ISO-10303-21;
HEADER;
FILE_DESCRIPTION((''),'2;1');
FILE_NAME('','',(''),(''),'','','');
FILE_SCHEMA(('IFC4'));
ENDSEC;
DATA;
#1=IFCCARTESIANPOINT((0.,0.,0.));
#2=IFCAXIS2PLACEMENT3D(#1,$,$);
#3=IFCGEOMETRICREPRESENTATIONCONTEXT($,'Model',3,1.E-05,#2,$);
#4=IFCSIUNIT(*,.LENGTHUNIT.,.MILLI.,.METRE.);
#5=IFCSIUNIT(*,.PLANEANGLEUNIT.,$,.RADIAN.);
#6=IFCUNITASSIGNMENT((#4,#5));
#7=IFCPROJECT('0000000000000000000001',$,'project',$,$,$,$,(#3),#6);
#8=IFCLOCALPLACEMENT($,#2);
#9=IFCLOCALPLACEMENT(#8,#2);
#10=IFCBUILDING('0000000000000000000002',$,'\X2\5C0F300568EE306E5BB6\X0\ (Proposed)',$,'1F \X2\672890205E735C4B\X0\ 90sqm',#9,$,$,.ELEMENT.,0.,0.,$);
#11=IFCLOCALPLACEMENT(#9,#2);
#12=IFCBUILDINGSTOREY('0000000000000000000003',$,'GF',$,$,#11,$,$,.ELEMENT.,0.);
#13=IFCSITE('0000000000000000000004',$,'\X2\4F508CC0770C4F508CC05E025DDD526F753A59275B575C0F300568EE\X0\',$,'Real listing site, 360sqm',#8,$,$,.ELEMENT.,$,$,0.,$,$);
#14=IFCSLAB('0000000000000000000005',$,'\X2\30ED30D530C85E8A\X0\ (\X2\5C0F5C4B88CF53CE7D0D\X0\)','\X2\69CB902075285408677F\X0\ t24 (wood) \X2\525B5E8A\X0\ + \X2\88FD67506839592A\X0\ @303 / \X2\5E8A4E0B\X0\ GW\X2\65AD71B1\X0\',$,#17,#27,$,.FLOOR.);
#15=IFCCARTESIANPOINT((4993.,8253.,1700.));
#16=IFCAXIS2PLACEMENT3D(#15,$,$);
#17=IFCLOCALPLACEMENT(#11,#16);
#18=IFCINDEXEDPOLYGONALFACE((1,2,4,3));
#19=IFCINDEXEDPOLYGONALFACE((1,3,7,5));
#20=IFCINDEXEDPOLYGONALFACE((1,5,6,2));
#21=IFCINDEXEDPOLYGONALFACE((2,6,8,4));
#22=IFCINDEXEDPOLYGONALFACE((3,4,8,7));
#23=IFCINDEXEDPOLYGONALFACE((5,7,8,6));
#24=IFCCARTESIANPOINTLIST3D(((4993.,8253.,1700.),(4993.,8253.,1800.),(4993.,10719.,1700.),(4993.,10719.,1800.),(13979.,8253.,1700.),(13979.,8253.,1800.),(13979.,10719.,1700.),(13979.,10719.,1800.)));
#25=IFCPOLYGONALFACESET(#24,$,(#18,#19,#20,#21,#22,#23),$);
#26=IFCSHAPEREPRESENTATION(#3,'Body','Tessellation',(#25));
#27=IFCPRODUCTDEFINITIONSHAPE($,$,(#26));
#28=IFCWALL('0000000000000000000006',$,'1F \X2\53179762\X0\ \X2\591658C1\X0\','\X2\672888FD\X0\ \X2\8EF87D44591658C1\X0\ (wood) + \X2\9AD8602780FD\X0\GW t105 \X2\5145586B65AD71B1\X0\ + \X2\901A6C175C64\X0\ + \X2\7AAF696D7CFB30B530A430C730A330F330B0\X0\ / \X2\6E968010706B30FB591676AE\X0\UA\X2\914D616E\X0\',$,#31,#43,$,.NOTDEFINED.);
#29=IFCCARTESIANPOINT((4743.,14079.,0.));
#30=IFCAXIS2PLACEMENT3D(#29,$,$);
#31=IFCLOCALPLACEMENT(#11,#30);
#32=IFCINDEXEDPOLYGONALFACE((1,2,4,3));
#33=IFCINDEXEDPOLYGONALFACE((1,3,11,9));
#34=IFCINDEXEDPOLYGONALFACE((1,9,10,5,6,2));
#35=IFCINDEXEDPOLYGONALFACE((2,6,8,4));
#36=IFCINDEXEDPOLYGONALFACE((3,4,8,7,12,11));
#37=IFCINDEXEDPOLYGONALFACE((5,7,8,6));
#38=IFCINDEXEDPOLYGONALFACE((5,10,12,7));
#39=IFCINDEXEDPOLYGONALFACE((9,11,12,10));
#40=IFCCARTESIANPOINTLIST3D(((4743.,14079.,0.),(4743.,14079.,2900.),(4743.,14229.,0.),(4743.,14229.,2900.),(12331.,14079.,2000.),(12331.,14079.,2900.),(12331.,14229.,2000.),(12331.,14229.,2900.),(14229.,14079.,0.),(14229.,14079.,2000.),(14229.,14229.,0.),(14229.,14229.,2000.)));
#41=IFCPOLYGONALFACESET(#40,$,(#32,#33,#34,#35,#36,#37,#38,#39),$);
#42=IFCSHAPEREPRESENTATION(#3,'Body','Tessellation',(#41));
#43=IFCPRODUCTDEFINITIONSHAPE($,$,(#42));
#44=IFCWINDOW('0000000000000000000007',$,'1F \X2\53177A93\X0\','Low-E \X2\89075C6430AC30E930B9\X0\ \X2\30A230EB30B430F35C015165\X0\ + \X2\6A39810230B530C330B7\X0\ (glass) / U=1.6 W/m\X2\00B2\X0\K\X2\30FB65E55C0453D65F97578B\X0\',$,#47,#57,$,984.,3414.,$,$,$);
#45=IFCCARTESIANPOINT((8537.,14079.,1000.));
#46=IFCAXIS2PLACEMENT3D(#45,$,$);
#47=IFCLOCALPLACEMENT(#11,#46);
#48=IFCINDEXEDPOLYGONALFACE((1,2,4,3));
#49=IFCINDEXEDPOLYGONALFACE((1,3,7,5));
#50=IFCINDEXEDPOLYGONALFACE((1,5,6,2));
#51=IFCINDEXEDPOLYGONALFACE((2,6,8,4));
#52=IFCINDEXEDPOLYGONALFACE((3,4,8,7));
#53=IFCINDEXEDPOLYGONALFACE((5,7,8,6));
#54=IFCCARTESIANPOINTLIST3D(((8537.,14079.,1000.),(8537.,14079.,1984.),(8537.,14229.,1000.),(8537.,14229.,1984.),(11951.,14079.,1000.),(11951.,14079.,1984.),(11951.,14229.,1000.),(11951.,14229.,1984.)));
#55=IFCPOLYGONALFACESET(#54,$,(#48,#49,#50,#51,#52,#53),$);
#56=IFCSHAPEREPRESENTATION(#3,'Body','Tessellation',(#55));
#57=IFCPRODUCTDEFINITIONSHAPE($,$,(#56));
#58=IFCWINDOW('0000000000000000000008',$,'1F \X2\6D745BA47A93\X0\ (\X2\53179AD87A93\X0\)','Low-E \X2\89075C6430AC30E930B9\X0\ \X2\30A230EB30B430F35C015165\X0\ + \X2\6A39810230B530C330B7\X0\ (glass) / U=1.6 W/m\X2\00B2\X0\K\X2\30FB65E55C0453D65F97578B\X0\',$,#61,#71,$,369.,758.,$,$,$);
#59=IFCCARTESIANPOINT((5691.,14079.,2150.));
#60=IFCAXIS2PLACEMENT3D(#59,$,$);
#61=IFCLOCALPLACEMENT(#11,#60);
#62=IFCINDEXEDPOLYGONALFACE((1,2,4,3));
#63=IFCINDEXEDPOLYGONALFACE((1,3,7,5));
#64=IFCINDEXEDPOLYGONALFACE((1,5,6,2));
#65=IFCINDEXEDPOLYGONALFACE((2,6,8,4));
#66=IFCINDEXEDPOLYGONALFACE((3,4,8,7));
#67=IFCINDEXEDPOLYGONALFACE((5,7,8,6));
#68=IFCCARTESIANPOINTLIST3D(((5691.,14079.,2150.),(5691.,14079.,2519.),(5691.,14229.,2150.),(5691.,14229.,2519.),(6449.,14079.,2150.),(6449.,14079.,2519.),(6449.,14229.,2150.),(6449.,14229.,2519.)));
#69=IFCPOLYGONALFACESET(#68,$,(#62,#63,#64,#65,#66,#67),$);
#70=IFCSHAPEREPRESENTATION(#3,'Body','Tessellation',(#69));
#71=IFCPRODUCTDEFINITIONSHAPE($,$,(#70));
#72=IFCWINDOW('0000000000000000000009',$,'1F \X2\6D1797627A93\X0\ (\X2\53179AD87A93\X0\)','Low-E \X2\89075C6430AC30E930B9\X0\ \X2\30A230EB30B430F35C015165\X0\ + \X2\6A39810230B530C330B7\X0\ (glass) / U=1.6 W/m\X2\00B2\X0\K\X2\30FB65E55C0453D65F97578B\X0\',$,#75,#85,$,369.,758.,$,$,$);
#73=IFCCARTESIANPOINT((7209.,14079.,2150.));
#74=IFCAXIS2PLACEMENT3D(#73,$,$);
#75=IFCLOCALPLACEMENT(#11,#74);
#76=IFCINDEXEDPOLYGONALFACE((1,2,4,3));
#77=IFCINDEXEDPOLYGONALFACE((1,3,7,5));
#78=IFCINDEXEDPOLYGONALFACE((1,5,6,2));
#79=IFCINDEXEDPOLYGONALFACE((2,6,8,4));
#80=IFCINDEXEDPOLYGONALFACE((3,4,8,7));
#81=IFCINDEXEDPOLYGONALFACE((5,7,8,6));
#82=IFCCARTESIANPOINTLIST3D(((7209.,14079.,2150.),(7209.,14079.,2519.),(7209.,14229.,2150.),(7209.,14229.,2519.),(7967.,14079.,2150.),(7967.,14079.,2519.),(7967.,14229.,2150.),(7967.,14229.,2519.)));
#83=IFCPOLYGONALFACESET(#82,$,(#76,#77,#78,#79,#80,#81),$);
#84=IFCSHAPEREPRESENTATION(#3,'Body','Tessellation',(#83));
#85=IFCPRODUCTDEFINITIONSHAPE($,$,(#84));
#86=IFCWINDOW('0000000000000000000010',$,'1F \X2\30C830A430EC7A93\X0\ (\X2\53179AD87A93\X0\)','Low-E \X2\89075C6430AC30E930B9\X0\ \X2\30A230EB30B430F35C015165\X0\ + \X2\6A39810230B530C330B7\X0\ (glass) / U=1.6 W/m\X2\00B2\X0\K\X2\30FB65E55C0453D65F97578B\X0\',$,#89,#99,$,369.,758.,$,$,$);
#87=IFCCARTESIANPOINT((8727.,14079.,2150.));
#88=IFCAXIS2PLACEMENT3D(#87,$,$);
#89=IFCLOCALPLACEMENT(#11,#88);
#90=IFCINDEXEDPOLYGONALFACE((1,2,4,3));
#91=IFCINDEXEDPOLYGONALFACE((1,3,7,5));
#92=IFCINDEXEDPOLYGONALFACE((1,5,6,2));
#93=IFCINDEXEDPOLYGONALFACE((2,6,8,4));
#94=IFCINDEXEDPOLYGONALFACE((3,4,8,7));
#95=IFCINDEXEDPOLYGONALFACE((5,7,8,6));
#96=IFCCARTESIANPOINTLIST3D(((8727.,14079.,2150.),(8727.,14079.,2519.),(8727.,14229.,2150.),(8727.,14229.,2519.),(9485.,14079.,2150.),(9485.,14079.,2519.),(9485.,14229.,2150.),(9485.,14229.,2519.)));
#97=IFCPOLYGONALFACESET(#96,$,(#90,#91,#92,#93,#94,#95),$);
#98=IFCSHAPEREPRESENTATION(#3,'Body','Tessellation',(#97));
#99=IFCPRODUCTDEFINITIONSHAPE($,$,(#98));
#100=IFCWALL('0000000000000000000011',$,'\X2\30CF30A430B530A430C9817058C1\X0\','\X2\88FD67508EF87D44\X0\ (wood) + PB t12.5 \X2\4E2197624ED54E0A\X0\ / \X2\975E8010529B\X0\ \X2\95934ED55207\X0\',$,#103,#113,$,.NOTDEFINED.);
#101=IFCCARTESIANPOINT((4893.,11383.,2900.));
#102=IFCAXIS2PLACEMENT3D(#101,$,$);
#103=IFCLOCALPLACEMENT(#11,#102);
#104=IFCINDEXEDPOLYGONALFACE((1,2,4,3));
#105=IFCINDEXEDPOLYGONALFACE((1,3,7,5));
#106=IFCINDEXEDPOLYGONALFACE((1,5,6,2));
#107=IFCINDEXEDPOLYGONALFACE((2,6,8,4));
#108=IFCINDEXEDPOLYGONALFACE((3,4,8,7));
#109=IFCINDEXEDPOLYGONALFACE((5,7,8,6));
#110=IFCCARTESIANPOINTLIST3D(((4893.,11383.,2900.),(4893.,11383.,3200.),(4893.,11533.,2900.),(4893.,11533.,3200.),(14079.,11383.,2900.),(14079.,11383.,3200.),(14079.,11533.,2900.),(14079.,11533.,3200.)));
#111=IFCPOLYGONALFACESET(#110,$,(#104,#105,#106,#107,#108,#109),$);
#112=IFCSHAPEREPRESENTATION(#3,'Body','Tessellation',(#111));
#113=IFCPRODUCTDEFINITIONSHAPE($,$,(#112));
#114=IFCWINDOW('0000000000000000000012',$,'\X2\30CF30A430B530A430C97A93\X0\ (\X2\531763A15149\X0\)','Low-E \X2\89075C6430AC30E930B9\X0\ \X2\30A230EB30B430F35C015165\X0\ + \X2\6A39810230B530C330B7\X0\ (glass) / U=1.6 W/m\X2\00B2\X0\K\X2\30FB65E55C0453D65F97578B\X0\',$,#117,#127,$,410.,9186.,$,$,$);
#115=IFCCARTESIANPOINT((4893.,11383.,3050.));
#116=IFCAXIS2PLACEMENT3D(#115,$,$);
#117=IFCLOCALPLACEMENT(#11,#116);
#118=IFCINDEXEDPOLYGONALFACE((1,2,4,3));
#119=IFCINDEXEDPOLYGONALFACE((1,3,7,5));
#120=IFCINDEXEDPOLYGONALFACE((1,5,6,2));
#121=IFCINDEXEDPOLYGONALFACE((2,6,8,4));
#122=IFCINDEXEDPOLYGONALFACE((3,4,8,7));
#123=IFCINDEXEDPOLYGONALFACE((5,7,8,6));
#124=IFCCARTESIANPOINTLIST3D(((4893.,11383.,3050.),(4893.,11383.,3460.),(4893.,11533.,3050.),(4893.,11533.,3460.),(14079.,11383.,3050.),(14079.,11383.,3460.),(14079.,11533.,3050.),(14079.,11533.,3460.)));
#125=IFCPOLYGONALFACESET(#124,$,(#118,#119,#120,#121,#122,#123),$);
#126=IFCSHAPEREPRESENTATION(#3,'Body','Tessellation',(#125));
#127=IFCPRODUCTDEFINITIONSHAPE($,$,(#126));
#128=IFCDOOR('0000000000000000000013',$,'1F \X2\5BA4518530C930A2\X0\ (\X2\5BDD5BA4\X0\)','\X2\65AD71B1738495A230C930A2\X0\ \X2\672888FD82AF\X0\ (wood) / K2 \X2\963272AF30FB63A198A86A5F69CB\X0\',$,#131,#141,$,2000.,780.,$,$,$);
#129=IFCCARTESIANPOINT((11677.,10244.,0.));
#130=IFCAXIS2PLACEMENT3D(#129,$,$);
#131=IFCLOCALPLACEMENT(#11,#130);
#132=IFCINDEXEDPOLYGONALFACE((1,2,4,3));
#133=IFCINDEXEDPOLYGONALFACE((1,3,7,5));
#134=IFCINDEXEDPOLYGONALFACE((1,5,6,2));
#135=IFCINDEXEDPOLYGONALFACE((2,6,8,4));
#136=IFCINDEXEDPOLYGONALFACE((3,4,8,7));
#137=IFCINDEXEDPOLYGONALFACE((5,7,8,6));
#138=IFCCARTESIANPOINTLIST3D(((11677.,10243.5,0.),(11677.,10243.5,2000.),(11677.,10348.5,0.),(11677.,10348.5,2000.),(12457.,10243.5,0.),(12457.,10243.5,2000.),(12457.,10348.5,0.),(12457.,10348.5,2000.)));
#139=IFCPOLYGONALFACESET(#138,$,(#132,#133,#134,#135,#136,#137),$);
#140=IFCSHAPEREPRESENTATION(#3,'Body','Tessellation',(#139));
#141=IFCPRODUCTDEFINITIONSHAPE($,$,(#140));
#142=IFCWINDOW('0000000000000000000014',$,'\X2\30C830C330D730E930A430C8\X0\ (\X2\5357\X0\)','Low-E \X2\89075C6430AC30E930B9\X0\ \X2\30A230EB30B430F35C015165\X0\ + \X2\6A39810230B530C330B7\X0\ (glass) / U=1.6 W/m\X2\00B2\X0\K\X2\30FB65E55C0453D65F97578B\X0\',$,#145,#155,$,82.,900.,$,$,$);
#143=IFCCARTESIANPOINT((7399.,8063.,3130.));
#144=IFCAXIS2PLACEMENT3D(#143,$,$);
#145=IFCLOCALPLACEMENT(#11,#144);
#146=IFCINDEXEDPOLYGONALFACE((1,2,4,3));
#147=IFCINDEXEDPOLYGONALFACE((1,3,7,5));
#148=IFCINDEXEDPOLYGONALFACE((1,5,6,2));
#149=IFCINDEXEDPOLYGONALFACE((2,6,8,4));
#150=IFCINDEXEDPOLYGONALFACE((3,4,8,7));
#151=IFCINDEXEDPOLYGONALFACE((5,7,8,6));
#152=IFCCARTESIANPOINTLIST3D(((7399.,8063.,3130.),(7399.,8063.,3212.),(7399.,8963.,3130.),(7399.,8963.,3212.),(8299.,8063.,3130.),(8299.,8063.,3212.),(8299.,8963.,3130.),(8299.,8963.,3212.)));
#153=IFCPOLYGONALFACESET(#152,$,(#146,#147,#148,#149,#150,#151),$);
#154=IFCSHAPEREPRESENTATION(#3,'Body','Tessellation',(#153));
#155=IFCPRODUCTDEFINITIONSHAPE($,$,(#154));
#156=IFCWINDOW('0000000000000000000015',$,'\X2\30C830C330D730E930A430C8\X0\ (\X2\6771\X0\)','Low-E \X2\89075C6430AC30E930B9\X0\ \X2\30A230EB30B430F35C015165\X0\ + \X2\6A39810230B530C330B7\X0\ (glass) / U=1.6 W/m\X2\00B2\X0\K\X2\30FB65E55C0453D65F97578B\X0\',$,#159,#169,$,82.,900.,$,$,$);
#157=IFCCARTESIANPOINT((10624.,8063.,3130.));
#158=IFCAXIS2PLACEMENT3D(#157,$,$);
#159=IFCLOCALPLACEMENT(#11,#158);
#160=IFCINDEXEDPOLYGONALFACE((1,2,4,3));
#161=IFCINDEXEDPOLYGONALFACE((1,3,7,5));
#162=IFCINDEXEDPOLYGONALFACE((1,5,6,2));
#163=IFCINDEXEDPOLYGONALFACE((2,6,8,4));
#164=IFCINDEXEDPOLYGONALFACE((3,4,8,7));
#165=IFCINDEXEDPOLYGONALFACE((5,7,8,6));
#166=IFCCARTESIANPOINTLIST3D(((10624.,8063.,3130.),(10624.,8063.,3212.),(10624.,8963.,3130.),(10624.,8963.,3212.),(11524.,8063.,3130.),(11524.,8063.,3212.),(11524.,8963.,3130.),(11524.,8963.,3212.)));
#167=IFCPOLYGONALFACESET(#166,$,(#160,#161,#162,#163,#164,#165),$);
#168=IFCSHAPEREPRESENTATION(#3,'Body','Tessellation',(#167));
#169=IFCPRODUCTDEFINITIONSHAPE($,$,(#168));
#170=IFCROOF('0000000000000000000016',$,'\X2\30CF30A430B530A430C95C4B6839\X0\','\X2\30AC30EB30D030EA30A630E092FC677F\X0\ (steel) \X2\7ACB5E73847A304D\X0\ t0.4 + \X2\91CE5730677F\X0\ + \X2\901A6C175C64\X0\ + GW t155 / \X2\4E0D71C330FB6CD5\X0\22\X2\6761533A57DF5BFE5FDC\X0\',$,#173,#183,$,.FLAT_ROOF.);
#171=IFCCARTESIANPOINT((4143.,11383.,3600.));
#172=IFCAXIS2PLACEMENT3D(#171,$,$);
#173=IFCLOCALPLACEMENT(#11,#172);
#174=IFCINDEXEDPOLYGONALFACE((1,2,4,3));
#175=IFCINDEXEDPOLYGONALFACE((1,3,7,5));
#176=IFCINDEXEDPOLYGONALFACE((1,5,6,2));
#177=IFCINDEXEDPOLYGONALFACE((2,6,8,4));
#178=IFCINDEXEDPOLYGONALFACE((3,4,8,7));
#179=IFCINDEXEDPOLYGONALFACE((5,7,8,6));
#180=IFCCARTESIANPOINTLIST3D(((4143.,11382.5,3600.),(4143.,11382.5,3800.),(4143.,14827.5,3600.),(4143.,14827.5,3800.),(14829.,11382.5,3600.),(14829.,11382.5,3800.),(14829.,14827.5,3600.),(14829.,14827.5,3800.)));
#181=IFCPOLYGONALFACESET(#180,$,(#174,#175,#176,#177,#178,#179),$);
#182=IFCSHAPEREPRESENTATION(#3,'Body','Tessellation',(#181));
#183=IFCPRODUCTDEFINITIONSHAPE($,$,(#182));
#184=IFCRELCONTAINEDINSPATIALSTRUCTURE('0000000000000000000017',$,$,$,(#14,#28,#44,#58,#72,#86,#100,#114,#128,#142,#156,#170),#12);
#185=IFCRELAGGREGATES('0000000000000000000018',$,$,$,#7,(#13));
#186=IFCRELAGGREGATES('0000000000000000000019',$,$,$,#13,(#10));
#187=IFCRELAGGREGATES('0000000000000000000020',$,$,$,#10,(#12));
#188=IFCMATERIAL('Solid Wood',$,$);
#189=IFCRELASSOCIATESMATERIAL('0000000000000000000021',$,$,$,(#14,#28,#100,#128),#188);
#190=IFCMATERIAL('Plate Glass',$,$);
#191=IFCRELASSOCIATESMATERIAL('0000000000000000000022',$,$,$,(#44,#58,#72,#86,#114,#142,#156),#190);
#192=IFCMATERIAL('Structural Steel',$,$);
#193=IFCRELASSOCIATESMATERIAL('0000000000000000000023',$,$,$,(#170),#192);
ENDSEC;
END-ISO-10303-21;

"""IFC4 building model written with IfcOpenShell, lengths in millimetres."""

from ifc_helpers import new_model, si_unit, frame, frame_2d, origin, place, context, project, spatial, rectangle, extrude, material, element, fill, save


model = new_model("IFC4")

# Units and contexts
model_context = context("Model", 3, precision=1e-05, world=origin())
ifc_project = project(units=[si_unit("LENGTHUNIT", "METRE", prefix="MILLI"), si_unit("PLANEANGLEUNIT", "RADIAN")], contexts=[model_context])

# Site, building, storey
site_placement = place(None, origin())
site = spatial("IfcSite", under=ifc_project, at=site_placement, Name="佐賀県佐賀市川副町大字小々森", ObjectType="Real listing site, 360sqm", CompositionType="ELEMENT", RefElevation=0.0)
building_placement = place(site_placement, origin())
building = spatial("IfcBuilding", under=site, at=building_placement, Name="小々森の家 (Proposed)", ObjectType="1F 木造平屋 90sqm", CompositionType="ELEMENT", ElevationOfRefHeight=0.0, ElevationOfTerrain=0.0)
storey_placement = place(building_placement, origin())
storey = spatial("IfcBuildingStorey", under=building, at=storey_placement, Name="GF", CompositionType="ELEMENT", Elevation=0.0)

# Slab
ifc_material_1 = material(Name="Solid Wood")
slab_placement = place(storey_placement, frame((4993.0, 8253.0, 1700.0)))
element("IfcSlab", 1, at=slab_placement, inside=storey, material=ifc_material_1, Name="ロフト床 (小屋裏収納)", Description="構造用合板 t24 (wood) 剛床 + 製材根太 @303 / 床下 GW断熱", PredefinedType="FLOOR", context=model_context, shape_type="SweptSolid", body=[
    extrude(rectangle(XDim=8986.0, YDim=2466.0, at=frame_2d((4493.0, 1233.0))), frame((4993.0, 8253.0, 1700.0)), (0.0, 0.0, 1.0), 100.0),
])

# Wall, openings, windows
wall_1_placement = place(storey_placement, frame((4743.0, 14079.0, 0.0)))
wall_1 = element("IfcWall", 2, at=wall_1_placement, inside=storey, material=ifc_material_1, Name="1F 北面 外壁", Description="木製 軸組外壁 (wood) + 高性能GW t105 充填断熱 + 通気層 + 窯業系サイディング / 準耐火・外皮UA配慮", PredefinedType="NOTDEFINED", context=model_context, shape_type="SweptSolid", body=[
    extrude(rectangle(XDim=9486.0, YDim=150.0, at=frame_2d((4743.0, 75.0))), frame((4743.0, 14079.0, 0.0)), (0.0, 0.0, 1.0), 2900.0),
])
opening_1_placement = place(storey_placement, frame((8537.0, 14079.0, 1000.0)))
opening_1 = element("IfcOpeningElement", 3, at=opening_1_placement, cuts=wall_1, PredefinedType="NOTDEFINED", context=model_context, shape_type="SweptSolid", body=[
    extrude(rectangle(XDim=3414.0, YDim=150.0, at=frame_2d((1707.0, 75.0))), frame((8537.0, 14079.0, 1000.0)), (0.0, 0.0, 1.0), 984.0),
])
opening_2_placement = place(storey_placement, frame((5691.0, 14079.0, 2150.0)))
opening_2 = element("IfcOpeningElement", 4, at=opening_2_placement, cuts=wall_1, PredefinedType="NOTDEFINED", context=model_context, shape_type="SweptSolid", body=[
    extrude(rectangle(XDim=758.0, YDim=150.0, at=frame_2d((379.0, 75.0))), frame((5691.0, 14079.0, 2150.0)), (0.0, 0.0, 1.0), 369.0),
])
opening_3_placement = place(storey_placement, frame((7209.0, 14079.0, 2150.0)))
opening_3 = element("IfcOpeningElement", 5, at=opening_3_placement, cuts=wall_1, PredefinedType="NOTDEFINED", context=model_context, shape_type="SweptSolid", body=[
    extrude(rectangle(XDim=758.0, YDim=150.0, at=frame_2d((379.0, 75.0))), frame((7209.0, 14079.0, 2150.0)), (0.0, 0.0, 1.0), 369.0),
])
opening_4_placement = place(storey_placement, frame((8727.0, 14079.0, 2150.0)))
opening_4 = element("IfcOpeningElement", 6, at=opening_4_placement, cuts=wall_1, PredefinedType="NOTDEFINED", context=model_context, shape_type="SweptSolid", body=[
    extrude(rectangle(XDim=758.0, YDim=150.0, at=frame_2d((379.0, 75.0))), frame((8727.0, 14079.0, 2150.0)), (0.0, 0.0, 1.0), 369.0),
])
ifc_material_2 = material(Name="Plate Glass")
window_1_placement = place(storey_placement, frame((8537.0, 14079.0, 1000.0)))
window_1 = element("IfcWindow", 7, at=window_1_placement, inside=storey, material=ifc_material_2, Name="1F 北窓", Description="Low-E 複層ガラス アルゴン封入 + 樹脂サッシ (glass) / U=1.6 W/m²K・日射取得型", OverallHeight=984.0, OverallWidth=3414.0, context=model_context, shape_type="SweptSolid", body=[
    extrude(rectangle(XDim=3414.0, YDim=150.0, at=frame_2d((1707.0, 75.0))), frame((8537.0, 14079.0, 1000.0)), (0.0, 0.0, 1.0), 984.0),
])
fill(opening_1, window_1)
window_2_placement = place(storey_placement, frame((5691.0, 14079.0, 2150.0)))
window_2 = element("IfcWindow", 8, at=window_2_placement, inside=storey, material=ifc_material_2, Name="1F 浴室窓 (北高窓)", Description="Low-E 複層ガラス アルゴン封入 + 樹脂サッシ (glass) / U=1.6 W/m²K・日射取得型", OverallHeight=369.0, OverallWidth=758.0, context=model_context, shape_type="SweptSolid", body=[
    extrude(rectangle(XDim=758.0, YDim=150.0, at=frame_2d((379.0, 75.0))), frame((5691.0, 14079.0, 2150.0)), (0.0, 0.0, 1.0), 369.0),
])
fill(opening_2, window_2)
window_3_placement = place(storey_placement, frame((7209.0, 14079.0, 2150.0)))
window_3 = element("IfcWindow", 9, at=window_3_placement, inside=storey, material=ifc_material_2, Name="1F 洗面窓 (北高窓)", Description="Low-E 複層ガラス アルゴン封入 + 樹脂サッシ (glass) / U=1.6 W/m²K・日射取得型", OverallHeight=369.0, OverallWidth=758.0, context=model_context, shape_type="SweptSolid", body=[
    extrude(rectangle(XDim=758.0, YDim=150.0, at=frame_2d((379.0, 75.0))), frame((7209.0, 14079.0, 2150.0)), (0.0, 0.0, 1.0), 369.0),
])
fill(opening_3, window_3)
window_4_placement = place(storey_placement, frame((8727.0, 14079.0, 2150.0)))
window_4 = element("IfcWindow", 10, at=window_4_placement, inside=storey, material=ifc_material_2, Name="1F トイレ窓 (北高窓)", Description="Low-E 複層ガラス アルゴン封入 + 樹脂サッシ (glass) / U=1.6 W/m²K・日射取得型", OverallHeight=369.0, OverallWidth=758.0, context=model_context, shape_type="SweptSolid", body=[
    extrude(rectangle(XDim=758.0, YDim=150.0, at=frame_2d((379.0, 75.0))), frame((8727.0, 14079.0, 2150.0)), (0.0, 0.0, 1.0), 369.0),
])
fill(opening_4, window_4)

# Wall, opening, window
wall_2_placement = place(storey_placement, frame((4893.0, 11383.0, 2900.0)))
wall_2 = element("IfcWall", 11, at=wall_2_placement, inside=storey, material=ifc_material_1, Name="ハイサイド腰壁", Description="製材軸組 (wood) + PB t12.5 両面仕上 / 非耐力 間仕切", PredefinedType="NOTDEFINED", context=model_context, shape_type="SweptSolid", body=[
    extrude(rectangle(XDim=9186.0, YDim=150.0, at=frame_2d((4593.0, 75.0))), frame((4893.0, 11383.0, 2900.0)), (0.0, 0.0, 1.0), 700.0),
])
opening_5_placement = place(storey_placement, frame((4893.0, 11383.0, 3050.0)))
opening_5 = element("IfcOpeningElement", 12, at=opening_5_placement, cuts=wall_2, PredefinedType="NOTDEFINED", context=model_context, shape_type="SweptSolid", body=[
    extrude(rectangle(XDim=9186.0, YDim=150.0, at=frame_2d((4593.0, 75.0))), frame((4893.0, 11383.0, 3050.0)), (0.0, 0.0, 1.0), 410.0),
])
window_5_placement = place(storey_placement, frame((4893.0, 11383.0, 3050.0)))
window_5 = element("IfcWindow", 13, at=window_5_placement, inside=storey, material=ifc_material_2, Name="ハイサイド窓 (北採光)", Description="Low-E 複層ガラス アルゴン封入 + 樹脂サッシ (glass) / U=1.6 W/m²K・日射取得型", OverallHeight=410.0, OverallWidth=9186.0, context=model_context, shape_type="SweptSolid", body=[
    extrude(rectangle(XDim=9186.0, YDim=150.0, at=frame_2d((4593.0, 75.0))), frame((4893.0, 11383.0, 3050.0)), (0.0, 0.0, 1.0), 410.0),
])
fill(opening_5, window_5)

# Door
door_1_placement = place(storey_placement, frame((11677.0, 10244.0, 0.0)))
element("IfcDoor", 14, at=door_1_placement, inside=storey, material=ifc_material_1, Name="1F 室内ドア (寝室)", Description="断熱玄関ドア 木製芯 (wood) / K2 防犯・採風機構", OverallHeight=2000.0, OverallWidth=780.0, context=model_context, shape_type="SweptSolid", body=[
    extrude(rectangle(XDim=780.0, YDim=105.0, at=frame_2d((390.0, 52.0))), frame((11677.0, 10244.0, 0.0)), (0.0, 0.0, 1.0), 2000.0),
])

# Windows
window_6_placement = place(storey_placement, frame((7399.0, 8063.0, 3130.0)))
element("IfcWindow", 15, at=window_6_placement, inside=storey, material=ifc_material_2, Name="トップライト (南)", Description="Low-E 複層ガラス アルゴン封入 + 樹脂サッシ (glass) / U=1.6 W/m²K・日射取得型", OverallHeight=82.0, OverallWidth=900.0, context=model_context, shape_type="SweptSolid", body=[
    extrude(rectangle(XDim=900.0, YDim=900.0, at=frame_2d((450.0, 450.0))), frame((7399.0, 8063.0, 3130.0)), (0.0, 0.0, 1.0), 82.0),
])
window_7_placement = place(storey_placement, frame((10624.0, 8063.0, 3130.0)))
element("IfcWindow", 16, at=window_7_placement, inside=storey, material=ifc_material_2, Name="トップライト (東)", Description="Low-E 複層ガラス アルゴン封入 + 樹脂サッシ (glass) / U=1.6 W/m²K・日射取得型", OverallHeight=82.0, OverallWidth=900.0, context=model_context, shape_type="SweptSolid", body=[
    extrude(rectangle(XDim=900.0, YDim=900.0, at=frame_2d((450.0, 450.0))), frame((10624.0, 8063.0, 3130.0)), (0.0, 0.0, 1.0), 82.0),
])

# Roof
ifc_material_3 = material(Name="Structural Steel")
roof_placement = place(storey_placement, frame((4143.0, 11383.0, 3600.0)))
element("IfcRoof", 17, at=roof_placement, inside=storey, material=ifc_material_3, Name="ハイサイド屋根", Description="ガルバリウム鋼板 (steel) 立平葺き t0.4 + 野地板 + 通気層 + GW t155 / 不燃・法22条区域対応", PredefinedType="FLAT_ROOF", context=model_context, shape_type="SweptSolid", body=[
    extrude(rectangle(XDim=10686.0, YDim=3445.0, at=frame_2d((5343.0, 1722.0))), frame((4143.0, 11383.0, 3600.0)), (0.0, 0.0, 1.0), 200.0),
])

save(model, "model.ifc")
